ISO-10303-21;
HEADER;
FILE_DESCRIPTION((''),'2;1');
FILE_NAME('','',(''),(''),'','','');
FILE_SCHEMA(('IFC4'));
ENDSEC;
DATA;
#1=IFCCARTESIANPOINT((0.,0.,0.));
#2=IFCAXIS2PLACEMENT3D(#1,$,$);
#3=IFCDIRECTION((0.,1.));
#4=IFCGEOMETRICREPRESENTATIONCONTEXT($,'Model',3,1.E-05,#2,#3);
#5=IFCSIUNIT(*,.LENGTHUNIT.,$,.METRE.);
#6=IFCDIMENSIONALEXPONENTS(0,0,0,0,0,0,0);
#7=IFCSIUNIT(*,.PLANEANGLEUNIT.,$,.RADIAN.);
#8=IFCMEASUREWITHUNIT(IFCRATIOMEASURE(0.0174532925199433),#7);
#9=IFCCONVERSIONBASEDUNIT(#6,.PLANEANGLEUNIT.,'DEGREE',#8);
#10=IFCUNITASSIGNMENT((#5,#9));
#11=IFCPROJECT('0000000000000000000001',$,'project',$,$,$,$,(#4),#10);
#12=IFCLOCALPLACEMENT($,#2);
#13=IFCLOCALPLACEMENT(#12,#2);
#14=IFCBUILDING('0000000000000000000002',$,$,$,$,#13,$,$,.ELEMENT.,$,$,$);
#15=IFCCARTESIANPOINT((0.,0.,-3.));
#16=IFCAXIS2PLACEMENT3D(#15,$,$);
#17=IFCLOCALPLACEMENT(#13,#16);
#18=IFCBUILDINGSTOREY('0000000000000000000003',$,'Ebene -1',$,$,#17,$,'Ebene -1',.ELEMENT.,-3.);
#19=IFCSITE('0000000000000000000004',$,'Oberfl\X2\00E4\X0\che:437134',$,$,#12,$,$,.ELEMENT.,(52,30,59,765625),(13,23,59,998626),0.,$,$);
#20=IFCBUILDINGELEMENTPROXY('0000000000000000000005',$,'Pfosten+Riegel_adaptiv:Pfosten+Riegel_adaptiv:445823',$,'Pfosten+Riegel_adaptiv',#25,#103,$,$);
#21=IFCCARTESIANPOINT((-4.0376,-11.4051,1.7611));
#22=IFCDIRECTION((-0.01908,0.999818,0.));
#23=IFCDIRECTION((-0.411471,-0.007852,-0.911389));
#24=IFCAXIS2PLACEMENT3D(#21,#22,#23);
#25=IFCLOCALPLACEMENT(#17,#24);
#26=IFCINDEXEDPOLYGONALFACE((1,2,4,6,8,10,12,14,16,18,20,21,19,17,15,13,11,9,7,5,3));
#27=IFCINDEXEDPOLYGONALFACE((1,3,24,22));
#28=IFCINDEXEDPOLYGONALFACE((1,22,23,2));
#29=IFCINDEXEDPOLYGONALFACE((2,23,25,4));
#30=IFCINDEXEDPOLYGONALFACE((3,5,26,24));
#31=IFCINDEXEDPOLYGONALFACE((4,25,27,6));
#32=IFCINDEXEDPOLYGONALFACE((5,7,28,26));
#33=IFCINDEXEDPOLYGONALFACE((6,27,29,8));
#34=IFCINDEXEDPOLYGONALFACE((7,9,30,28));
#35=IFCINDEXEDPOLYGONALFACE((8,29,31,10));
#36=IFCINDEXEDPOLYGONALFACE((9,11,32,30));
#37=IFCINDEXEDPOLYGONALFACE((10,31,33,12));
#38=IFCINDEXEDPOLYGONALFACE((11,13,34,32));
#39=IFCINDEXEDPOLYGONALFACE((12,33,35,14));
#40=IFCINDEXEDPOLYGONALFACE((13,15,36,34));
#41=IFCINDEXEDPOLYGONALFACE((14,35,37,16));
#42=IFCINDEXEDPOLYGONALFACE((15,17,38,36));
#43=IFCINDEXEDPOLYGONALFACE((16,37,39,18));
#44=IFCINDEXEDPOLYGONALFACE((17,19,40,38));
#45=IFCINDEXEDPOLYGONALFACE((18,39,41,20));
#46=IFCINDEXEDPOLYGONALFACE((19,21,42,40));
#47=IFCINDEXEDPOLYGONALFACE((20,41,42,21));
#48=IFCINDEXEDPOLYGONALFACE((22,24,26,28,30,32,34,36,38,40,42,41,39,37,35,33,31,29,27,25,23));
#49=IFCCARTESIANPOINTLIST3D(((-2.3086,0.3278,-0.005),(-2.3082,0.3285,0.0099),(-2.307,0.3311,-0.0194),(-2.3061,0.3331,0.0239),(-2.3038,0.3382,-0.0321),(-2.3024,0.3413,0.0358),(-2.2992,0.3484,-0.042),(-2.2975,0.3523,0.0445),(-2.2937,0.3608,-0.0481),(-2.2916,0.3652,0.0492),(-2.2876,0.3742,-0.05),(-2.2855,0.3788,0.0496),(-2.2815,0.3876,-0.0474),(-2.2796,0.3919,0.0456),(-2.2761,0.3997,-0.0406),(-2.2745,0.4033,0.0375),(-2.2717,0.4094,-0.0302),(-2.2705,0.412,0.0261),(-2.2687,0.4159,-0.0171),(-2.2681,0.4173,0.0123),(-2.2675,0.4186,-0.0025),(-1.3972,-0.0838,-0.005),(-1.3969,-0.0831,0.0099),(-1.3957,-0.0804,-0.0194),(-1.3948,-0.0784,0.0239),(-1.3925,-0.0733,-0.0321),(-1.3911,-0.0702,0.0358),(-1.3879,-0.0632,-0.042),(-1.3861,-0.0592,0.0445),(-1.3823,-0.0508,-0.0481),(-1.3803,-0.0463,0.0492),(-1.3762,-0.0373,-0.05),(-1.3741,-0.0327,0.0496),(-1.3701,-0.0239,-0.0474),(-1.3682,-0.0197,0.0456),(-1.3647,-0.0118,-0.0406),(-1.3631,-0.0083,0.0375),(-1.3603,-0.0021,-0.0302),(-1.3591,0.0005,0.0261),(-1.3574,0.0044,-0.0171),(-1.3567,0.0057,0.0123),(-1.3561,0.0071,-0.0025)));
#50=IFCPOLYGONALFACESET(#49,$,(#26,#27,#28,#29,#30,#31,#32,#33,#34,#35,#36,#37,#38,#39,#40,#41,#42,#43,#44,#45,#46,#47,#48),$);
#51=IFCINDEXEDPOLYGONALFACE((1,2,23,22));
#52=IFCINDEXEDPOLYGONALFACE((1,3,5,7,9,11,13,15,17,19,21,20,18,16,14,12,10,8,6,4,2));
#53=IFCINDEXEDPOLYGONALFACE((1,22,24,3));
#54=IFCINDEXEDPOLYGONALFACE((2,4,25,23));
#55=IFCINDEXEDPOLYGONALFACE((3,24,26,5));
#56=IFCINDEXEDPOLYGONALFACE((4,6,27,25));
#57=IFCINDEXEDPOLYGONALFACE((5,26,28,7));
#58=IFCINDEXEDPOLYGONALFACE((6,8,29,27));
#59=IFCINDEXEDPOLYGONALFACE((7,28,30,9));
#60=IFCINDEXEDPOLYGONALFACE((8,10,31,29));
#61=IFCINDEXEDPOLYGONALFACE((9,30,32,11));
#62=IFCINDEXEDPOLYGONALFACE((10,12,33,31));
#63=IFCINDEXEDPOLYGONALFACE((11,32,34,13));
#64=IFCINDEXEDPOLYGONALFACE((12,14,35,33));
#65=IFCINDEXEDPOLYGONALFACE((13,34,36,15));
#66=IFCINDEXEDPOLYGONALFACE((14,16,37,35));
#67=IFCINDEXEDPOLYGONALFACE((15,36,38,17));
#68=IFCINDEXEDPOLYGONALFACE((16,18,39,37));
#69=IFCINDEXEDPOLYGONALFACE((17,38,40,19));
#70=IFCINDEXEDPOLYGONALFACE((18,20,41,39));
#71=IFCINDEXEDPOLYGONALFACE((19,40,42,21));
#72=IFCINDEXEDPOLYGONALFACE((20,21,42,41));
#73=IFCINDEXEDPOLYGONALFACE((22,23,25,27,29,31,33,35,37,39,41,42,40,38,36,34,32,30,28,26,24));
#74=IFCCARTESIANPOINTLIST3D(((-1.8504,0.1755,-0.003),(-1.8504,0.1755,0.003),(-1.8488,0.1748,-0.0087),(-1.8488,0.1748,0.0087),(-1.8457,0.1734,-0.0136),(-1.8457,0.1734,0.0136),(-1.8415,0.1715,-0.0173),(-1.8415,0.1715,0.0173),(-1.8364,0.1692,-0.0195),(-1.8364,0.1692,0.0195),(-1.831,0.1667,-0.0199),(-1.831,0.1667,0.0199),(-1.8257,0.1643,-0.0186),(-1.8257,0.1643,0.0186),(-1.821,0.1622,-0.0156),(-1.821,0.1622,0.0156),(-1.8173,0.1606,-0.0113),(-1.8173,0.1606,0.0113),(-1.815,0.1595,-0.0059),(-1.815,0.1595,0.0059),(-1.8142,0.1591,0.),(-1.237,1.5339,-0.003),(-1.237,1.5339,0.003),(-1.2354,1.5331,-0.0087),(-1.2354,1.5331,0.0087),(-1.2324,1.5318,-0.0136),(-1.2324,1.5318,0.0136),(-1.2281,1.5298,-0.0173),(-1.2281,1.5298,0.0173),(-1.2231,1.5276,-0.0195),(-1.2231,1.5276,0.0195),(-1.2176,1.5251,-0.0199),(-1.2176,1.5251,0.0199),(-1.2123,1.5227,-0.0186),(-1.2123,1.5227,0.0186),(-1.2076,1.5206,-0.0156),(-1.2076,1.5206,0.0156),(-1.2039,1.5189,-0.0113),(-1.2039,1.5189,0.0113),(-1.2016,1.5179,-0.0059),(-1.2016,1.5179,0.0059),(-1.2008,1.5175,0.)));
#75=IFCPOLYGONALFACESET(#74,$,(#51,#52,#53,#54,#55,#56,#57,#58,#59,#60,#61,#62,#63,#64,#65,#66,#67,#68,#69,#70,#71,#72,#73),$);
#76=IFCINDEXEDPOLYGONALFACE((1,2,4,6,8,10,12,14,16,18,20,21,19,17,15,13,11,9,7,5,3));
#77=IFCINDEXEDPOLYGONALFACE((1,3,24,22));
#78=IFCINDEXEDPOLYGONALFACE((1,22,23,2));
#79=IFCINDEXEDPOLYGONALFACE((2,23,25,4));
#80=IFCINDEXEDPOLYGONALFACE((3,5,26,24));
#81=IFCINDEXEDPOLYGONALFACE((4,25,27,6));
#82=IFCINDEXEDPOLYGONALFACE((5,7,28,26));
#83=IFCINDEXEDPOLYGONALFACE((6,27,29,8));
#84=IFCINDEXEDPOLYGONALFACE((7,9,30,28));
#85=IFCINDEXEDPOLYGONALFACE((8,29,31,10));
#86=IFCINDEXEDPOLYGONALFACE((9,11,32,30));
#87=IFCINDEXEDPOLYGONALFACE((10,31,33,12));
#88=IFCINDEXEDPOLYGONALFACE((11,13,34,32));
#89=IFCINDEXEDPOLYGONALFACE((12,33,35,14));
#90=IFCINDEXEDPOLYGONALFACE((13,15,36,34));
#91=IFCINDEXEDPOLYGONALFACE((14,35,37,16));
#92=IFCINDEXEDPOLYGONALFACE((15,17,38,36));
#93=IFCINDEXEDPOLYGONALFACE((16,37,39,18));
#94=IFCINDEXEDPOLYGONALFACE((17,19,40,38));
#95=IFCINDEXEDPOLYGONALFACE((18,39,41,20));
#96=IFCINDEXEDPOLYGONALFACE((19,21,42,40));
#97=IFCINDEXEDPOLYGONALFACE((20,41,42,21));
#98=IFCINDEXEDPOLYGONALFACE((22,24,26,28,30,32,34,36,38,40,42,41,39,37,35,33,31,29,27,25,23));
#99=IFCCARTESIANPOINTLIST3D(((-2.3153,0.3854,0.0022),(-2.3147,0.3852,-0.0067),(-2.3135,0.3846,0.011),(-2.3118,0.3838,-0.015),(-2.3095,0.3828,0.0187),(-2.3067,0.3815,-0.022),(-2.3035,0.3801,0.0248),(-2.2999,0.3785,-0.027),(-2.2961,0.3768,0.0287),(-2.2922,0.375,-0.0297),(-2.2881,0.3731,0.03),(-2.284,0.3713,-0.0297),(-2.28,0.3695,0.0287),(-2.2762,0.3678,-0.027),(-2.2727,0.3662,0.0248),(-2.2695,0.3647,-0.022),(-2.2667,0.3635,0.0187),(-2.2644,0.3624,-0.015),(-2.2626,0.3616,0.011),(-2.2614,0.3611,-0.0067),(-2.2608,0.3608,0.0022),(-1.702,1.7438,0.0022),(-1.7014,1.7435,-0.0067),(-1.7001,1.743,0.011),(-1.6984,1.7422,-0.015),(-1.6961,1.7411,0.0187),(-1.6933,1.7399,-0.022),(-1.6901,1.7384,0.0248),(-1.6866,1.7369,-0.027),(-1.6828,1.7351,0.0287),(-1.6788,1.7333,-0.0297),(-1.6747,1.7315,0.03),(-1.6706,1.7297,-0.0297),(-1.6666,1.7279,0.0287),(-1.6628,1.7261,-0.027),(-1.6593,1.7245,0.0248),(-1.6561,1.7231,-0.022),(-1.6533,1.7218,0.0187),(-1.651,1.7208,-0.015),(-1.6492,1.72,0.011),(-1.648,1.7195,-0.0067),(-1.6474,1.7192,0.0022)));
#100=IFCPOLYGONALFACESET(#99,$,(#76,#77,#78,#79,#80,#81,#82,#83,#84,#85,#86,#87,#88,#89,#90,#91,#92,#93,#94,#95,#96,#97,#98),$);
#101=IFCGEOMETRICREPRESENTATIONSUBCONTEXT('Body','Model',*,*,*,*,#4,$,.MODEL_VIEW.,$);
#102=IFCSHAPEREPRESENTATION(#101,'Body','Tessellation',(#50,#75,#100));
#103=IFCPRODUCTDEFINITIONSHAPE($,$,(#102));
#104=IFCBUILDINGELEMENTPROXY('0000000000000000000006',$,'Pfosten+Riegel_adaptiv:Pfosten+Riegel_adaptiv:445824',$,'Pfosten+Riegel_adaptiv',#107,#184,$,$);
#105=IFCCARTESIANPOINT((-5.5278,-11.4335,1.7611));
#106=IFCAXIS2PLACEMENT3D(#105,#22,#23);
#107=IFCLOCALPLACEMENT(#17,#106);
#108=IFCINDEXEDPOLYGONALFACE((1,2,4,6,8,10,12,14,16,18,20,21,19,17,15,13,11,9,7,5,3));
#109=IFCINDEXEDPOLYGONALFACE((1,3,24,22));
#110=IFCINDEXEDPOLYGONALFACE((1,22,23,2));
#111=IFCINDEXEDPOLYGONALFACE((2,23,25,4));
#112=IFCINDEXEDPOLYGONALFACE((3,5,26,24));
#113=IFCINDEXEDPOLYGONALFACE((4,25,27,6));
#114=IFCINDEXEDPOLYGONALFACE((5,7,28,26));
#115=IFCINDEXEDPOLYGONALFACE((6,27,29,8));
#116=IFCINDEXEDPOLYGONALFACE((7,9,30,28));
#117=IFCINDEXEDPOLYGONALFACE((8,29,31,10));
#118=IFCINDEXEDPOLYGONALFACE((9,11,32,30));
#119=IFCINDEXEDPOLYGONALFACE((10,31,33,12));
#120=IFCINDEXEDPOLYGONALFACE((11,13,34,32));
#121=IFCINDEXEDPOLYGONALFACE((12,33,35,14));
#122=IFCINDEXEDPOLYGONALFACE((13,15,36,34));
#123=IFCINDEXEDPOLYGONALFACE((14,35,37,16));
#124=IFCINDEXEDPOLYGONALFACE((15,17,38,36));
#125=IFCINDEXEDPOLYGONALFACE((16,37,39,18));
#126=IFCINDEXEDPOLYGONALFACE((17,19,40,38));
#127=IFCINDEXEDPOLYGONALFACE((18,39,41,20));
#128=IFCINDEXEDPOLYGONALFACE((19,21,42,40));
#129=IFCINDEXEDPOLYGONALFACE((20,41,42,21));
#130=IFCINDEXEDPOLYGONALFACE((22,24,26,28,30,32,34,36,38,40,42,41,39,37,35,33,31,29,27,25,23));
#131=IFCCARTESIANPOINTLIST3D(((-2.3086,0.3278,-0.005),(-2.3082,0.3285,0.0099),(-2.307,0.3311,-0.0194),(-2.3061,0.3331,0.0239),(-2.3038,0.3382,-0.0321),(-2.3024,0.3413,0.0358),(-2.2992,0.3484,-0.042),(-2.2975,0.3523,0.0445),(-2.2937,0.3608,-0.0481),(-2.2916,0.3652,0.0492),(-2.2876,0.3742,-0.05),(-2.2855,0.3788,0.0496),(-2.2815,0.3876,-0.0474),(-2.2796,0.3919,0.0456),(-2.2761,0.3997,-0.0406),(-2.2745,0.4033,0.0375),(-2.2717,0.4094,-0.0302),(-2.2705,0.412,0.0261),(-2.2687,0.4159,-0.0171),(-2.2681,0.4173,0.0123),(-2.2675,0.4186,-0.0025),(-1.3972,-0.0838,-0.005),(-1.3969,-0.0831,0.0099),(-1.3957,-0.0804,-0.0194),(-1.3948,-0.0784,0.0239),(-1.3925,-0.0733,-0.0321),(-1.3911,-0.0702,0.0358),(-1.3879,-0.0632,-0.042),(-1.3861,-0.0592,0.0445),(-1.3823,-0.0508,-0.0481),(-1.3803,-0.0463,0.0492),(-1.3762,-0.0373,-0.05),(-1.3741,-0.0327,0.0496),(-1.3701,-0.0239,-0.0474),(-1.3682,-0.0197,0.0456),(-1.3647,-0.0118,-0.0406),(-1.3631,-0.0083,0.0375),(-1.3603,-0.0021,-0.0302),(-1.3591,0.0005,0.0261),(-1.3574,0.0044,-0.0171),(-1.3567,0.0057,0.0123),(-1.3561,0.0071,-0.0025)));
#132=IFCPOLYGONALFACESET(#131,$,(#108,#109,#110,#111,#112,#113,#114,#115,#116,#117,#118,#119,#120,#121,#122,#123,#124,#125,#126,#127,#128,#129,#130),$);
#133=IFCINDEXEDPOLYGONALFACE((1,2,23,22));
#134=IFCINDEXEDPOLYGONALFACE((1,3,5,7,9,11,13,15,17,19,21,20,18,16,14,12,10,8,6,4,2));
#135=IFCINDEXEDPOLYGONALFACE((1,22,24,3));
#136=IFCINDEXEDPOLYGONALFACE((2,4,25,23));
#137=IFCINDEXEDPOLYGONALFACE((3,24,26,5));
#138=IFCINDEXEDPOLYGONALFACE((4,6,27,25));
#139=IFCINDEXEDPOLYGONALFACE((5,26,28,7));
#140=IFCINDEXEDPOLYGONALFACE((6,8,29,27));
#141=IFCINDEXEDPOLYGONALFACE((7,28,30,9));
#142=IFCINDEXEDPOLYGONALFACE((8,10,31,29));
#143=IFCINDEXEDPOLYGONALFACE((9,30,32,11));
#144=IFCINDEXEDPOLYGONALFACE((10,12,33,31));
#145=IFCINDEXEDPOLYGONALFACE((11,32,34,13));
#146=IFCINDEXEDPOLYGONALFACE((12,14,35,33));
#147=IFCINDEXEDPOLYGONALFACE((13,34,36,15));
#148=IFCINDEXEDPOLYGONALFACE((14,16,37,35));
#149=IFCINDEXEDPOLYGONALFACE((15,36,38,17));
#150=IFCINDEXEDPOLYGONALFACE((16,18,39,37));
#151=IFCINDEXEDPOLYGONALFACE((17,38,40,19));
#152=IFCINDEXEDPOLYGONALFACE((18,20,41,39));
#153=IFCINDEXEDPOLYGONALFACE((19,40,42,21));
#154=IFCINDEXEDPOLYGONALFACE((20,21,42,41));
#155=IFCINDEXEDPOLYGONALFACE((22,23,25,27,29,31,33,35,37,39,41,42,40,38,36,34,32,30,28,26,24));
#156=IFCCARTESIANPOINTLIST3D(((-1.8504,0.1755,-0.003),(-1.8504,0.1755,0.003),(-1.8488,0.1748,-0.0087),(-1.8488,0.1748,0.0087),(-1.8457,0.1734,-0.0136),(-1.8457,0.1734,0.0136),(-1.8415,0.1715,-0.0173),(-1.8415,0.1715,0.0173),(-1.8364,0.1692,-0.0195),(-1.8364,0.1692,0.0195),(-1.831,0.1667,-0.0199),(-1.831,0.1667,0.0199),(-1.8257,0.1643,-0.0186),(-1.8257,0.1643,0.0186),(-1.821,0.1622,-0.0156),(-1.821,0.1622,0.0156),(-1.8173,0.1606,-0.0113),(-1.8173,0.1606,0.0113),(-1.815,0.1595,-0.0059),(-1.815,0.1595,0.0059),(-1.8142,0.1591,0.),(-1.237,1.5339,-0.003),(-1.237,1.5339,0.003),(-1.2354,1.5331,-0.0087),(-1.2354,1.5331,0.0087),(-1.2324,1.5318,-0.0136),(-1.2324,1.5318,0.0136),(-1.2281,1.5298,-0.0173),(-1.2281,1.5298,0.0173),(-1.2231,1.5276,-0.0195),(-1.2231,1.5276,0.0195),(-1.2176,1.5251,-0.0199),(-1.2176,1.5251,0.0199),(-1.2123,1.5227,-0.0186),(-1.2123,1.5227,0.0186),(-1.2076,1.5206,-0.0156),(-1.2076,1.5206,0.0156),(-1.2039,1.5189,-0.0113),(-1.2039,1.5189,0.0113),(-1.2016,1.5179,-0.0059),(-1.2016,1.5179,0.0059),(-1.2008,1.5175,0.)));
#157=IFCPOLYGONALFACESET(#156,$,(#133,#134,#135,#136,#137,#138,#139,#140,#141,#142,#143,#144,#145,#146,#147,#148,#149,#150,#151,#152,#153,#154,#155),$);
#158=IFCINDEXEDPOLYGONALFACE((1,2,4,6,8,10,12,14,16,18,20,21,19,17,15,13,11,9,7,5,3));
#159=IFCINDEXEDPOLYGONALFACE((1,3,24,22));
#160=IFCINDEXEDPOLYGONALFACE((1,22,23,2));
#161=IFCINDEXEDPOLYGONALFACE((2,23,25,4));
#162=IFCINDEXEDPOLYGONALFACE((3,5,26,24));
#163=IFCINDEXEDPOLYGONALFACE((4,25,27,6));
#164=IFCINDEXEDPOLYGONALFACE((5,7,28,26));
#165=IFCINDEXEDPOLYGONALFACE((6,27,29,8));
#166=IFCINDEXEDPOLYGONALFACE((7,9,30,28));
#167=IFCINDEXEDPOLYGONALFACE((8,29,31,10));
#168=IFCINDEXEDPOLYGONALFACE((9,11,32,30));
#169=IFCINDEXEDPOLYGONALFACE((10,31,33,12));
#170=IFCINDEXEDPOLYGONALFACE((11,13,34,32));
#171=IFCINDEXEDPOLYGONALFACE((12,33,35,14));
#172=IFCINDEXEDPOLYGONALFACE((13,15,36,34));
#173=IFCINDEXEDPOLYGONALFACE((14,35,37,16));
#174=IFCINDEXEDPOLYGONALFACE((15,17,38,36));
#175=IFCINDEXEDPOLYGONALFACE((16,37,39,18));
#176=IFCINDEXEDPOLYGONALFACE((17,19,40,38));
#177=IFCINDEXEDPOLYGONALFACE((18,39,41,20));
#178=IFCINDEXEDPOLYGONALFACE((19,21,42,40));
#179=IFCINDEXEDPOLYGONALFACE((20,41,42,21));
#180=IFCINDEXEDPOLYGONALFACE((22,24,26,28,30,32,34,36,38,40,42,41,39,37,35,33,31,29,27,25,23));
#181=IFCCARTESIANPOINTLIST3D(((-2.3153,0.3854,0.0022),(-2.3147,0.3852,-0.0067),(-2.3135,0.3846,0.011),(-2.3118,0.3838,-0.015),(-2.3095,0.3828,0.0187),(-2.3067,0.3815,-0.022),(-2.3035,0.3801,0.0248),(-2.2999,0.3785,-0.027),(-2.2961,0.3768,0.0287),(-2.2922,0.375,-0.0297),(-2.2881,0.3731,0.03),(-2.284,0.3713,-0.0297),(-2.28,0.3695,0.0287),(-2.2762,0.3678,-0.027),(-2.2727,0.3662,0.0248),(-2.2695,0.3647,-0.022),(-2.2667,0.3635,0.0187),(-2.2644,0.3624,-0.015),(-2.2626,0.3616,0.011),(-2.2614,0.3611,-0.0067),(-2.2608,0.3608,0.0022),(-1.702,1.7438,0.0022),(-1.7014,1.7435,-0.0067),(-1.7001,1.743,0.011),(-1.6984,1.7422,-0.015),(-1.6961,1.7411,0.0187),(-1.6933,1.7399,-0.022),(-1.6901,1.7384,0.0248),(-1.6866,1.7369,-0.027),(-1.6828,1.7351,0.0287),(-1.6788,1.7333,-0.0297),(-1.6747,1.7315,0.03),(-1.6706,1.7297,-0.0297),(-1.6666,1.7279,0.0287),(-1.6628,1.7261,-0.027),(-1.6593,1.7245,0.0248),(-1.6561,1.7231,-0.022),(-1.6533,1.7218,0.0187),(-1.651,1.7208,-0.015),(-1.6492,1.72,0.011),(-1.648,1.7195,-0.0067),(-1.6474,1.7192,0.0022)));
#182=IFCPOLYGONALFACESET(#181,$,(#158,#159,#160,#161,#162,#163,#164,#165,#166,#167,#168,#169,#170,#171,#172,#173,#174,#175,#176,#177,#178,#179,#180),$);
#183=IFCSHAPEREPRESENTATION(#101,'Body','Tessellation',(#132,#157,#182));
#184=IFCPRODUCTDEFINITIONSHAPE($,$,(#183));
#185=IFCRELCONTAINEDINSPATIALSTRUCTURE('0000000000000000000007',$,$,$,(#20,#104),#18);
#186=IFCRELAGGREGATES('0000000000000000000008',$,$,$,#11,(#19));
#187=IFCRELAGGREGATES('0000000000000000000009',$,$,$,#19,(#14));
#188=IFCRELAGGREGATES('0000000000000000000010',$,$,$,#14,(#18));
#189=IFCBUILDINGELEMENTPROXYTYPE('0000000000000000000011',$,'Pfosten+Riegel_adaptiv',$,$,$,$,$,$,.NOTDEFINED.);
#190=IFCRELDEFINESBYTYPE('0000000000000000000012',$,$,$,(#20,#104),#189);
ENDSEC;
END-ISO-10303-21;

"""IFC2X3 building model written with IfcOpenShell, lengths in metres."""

from ifc_helpers import new_model, entity, si_unit, converted_unit, direction, frame, frame_2d, origin, place, context, subcontext, project, spatial, circle, extrude, source, transform, mapped, type_object, type_shapes, element, save


model = new_model("IFC2X3")

# Units and contexts
model_context = context("Model", 3, precision=1e-05, world=origin(), true_north=direction((0.0, 1.0)))
body_context = subcontext(model_context, "Body", "Model", "MODEL_VIEW")
ifc_project = project(units=[si_unit("LENGTHUNIT", "METRE"), converted_unit("PLANEANGLEUNIT", "DEGREE", entity("IfcRatioMeasure", 0.0174532925199433), si_unit("PLANEANGLEUNIT", "RADIAN"), dimensions=[0, 0, 0, 0, 0, 0, 0])], contexts=[model_context])

# Site, building, storey
site_placement = place(None, origin())
site = spatial("IfcSite", under=ifc_project, at=site_placement, Name="Oberfläche:437134", CompositionType="ELEMENT", RefLatitude=(52, 30, 59, 765625), RefLongitude=(13, 23, 59, 998626), RefElevation=0.0)
building_placement = place(site_placement, origin())
building = spatial("IfcBuilding", under=site, at=building_placement, CompositionType="ELEMENT")
storey_placement = place(building_placement, frame((0.0, 0.0, -3.0)))
storey = spatial("IfcBuildingStorey", under=building, at=storey_placement, Name="Ebene -1", LongName="Ebene -1", CompositionType="ELEMENT", Elevation=-3.0)

# Building element proxies
building_element_proxy_type_1 = type_object("IfcBuildingElementProxyType", Name="Pfosten+Riegel_adaptiv", PredefinedType="NOTDEFINED")
shared_shape_1 = source(origin(), body_context, "Body", "SweptSolid", [
    extrude(circle(Radius=0.05, at=frame_2d((0.0, 0.0), x_axis=(1.0, 0.0))), frame((-2.2881, 0.3731, 0.0), z_axis=(0.911389, -0.411546, 0.0), x_axis=(0.16937, 0.375078, 0.911389)), (0.0, 0.0, 1.0), 1.0),
    extrude(circle(Radius=0.02, at=frame_2d((0.0, 0.0), x_axis=(1.0, 0.0))), frame((-1.8324, 0.1674, 0.0), z_axis=(0.411546, 0.911389, 0.0), x_axis=(0.911389, -0.411546, 0.0)), (0.0, 0.0, 1.0), 1.4904),
    extrude(circle(Radius=0.03, at=frame_2d((0.0, 0.0), x_axis=(1.0, 0.0))), frame((-2.2881, 0.3731, 0.0), z_axis=(0.411546, 0.911389, 0.0), x_axis=(0.0, 0.0, 1.0)), (0.0, 0.0, 1.0), 1.4904),
])
type_shapes(building_element_proxy_type_1, [shared_shape_1])
for number, where, z_axis, x_axis, name in (
    (1, (-4.0376, -11.4051, 1.7611), (-0.01908, 0.999818, 0.0), (-0.411471, -0.007852, -0.911389), "Pfosten+Riegel_adaptiv:Pfosten+Riegel_adaptiv:445823"),
    (2, (-5.5278, -11.4335, 1.7611), (-0.01908, 0.999818, 0.0), (-0.411471, -0.007852, -0.911389), "Pfosten+Riegel_adaptiv:Pfosten+Riegel_adaptiv:445824"),
):
    element("IfcBuildingElementProxy", number, at=place(storey_placement, frame(where, z_axis=z_axis, x_axis=x_axis)), inside=storey, type_object=building_element_proxy_type_1, Name=name, ObjectType="Pfosten+Riegel_adaptiv", context=body_context, shape_type="MappedRepresentation", body=[
        mapped(shared_shape_1, transform((0.0, 0.0, 0.0), scale=1.0)),
    ])

save(model, "model.ifc")
